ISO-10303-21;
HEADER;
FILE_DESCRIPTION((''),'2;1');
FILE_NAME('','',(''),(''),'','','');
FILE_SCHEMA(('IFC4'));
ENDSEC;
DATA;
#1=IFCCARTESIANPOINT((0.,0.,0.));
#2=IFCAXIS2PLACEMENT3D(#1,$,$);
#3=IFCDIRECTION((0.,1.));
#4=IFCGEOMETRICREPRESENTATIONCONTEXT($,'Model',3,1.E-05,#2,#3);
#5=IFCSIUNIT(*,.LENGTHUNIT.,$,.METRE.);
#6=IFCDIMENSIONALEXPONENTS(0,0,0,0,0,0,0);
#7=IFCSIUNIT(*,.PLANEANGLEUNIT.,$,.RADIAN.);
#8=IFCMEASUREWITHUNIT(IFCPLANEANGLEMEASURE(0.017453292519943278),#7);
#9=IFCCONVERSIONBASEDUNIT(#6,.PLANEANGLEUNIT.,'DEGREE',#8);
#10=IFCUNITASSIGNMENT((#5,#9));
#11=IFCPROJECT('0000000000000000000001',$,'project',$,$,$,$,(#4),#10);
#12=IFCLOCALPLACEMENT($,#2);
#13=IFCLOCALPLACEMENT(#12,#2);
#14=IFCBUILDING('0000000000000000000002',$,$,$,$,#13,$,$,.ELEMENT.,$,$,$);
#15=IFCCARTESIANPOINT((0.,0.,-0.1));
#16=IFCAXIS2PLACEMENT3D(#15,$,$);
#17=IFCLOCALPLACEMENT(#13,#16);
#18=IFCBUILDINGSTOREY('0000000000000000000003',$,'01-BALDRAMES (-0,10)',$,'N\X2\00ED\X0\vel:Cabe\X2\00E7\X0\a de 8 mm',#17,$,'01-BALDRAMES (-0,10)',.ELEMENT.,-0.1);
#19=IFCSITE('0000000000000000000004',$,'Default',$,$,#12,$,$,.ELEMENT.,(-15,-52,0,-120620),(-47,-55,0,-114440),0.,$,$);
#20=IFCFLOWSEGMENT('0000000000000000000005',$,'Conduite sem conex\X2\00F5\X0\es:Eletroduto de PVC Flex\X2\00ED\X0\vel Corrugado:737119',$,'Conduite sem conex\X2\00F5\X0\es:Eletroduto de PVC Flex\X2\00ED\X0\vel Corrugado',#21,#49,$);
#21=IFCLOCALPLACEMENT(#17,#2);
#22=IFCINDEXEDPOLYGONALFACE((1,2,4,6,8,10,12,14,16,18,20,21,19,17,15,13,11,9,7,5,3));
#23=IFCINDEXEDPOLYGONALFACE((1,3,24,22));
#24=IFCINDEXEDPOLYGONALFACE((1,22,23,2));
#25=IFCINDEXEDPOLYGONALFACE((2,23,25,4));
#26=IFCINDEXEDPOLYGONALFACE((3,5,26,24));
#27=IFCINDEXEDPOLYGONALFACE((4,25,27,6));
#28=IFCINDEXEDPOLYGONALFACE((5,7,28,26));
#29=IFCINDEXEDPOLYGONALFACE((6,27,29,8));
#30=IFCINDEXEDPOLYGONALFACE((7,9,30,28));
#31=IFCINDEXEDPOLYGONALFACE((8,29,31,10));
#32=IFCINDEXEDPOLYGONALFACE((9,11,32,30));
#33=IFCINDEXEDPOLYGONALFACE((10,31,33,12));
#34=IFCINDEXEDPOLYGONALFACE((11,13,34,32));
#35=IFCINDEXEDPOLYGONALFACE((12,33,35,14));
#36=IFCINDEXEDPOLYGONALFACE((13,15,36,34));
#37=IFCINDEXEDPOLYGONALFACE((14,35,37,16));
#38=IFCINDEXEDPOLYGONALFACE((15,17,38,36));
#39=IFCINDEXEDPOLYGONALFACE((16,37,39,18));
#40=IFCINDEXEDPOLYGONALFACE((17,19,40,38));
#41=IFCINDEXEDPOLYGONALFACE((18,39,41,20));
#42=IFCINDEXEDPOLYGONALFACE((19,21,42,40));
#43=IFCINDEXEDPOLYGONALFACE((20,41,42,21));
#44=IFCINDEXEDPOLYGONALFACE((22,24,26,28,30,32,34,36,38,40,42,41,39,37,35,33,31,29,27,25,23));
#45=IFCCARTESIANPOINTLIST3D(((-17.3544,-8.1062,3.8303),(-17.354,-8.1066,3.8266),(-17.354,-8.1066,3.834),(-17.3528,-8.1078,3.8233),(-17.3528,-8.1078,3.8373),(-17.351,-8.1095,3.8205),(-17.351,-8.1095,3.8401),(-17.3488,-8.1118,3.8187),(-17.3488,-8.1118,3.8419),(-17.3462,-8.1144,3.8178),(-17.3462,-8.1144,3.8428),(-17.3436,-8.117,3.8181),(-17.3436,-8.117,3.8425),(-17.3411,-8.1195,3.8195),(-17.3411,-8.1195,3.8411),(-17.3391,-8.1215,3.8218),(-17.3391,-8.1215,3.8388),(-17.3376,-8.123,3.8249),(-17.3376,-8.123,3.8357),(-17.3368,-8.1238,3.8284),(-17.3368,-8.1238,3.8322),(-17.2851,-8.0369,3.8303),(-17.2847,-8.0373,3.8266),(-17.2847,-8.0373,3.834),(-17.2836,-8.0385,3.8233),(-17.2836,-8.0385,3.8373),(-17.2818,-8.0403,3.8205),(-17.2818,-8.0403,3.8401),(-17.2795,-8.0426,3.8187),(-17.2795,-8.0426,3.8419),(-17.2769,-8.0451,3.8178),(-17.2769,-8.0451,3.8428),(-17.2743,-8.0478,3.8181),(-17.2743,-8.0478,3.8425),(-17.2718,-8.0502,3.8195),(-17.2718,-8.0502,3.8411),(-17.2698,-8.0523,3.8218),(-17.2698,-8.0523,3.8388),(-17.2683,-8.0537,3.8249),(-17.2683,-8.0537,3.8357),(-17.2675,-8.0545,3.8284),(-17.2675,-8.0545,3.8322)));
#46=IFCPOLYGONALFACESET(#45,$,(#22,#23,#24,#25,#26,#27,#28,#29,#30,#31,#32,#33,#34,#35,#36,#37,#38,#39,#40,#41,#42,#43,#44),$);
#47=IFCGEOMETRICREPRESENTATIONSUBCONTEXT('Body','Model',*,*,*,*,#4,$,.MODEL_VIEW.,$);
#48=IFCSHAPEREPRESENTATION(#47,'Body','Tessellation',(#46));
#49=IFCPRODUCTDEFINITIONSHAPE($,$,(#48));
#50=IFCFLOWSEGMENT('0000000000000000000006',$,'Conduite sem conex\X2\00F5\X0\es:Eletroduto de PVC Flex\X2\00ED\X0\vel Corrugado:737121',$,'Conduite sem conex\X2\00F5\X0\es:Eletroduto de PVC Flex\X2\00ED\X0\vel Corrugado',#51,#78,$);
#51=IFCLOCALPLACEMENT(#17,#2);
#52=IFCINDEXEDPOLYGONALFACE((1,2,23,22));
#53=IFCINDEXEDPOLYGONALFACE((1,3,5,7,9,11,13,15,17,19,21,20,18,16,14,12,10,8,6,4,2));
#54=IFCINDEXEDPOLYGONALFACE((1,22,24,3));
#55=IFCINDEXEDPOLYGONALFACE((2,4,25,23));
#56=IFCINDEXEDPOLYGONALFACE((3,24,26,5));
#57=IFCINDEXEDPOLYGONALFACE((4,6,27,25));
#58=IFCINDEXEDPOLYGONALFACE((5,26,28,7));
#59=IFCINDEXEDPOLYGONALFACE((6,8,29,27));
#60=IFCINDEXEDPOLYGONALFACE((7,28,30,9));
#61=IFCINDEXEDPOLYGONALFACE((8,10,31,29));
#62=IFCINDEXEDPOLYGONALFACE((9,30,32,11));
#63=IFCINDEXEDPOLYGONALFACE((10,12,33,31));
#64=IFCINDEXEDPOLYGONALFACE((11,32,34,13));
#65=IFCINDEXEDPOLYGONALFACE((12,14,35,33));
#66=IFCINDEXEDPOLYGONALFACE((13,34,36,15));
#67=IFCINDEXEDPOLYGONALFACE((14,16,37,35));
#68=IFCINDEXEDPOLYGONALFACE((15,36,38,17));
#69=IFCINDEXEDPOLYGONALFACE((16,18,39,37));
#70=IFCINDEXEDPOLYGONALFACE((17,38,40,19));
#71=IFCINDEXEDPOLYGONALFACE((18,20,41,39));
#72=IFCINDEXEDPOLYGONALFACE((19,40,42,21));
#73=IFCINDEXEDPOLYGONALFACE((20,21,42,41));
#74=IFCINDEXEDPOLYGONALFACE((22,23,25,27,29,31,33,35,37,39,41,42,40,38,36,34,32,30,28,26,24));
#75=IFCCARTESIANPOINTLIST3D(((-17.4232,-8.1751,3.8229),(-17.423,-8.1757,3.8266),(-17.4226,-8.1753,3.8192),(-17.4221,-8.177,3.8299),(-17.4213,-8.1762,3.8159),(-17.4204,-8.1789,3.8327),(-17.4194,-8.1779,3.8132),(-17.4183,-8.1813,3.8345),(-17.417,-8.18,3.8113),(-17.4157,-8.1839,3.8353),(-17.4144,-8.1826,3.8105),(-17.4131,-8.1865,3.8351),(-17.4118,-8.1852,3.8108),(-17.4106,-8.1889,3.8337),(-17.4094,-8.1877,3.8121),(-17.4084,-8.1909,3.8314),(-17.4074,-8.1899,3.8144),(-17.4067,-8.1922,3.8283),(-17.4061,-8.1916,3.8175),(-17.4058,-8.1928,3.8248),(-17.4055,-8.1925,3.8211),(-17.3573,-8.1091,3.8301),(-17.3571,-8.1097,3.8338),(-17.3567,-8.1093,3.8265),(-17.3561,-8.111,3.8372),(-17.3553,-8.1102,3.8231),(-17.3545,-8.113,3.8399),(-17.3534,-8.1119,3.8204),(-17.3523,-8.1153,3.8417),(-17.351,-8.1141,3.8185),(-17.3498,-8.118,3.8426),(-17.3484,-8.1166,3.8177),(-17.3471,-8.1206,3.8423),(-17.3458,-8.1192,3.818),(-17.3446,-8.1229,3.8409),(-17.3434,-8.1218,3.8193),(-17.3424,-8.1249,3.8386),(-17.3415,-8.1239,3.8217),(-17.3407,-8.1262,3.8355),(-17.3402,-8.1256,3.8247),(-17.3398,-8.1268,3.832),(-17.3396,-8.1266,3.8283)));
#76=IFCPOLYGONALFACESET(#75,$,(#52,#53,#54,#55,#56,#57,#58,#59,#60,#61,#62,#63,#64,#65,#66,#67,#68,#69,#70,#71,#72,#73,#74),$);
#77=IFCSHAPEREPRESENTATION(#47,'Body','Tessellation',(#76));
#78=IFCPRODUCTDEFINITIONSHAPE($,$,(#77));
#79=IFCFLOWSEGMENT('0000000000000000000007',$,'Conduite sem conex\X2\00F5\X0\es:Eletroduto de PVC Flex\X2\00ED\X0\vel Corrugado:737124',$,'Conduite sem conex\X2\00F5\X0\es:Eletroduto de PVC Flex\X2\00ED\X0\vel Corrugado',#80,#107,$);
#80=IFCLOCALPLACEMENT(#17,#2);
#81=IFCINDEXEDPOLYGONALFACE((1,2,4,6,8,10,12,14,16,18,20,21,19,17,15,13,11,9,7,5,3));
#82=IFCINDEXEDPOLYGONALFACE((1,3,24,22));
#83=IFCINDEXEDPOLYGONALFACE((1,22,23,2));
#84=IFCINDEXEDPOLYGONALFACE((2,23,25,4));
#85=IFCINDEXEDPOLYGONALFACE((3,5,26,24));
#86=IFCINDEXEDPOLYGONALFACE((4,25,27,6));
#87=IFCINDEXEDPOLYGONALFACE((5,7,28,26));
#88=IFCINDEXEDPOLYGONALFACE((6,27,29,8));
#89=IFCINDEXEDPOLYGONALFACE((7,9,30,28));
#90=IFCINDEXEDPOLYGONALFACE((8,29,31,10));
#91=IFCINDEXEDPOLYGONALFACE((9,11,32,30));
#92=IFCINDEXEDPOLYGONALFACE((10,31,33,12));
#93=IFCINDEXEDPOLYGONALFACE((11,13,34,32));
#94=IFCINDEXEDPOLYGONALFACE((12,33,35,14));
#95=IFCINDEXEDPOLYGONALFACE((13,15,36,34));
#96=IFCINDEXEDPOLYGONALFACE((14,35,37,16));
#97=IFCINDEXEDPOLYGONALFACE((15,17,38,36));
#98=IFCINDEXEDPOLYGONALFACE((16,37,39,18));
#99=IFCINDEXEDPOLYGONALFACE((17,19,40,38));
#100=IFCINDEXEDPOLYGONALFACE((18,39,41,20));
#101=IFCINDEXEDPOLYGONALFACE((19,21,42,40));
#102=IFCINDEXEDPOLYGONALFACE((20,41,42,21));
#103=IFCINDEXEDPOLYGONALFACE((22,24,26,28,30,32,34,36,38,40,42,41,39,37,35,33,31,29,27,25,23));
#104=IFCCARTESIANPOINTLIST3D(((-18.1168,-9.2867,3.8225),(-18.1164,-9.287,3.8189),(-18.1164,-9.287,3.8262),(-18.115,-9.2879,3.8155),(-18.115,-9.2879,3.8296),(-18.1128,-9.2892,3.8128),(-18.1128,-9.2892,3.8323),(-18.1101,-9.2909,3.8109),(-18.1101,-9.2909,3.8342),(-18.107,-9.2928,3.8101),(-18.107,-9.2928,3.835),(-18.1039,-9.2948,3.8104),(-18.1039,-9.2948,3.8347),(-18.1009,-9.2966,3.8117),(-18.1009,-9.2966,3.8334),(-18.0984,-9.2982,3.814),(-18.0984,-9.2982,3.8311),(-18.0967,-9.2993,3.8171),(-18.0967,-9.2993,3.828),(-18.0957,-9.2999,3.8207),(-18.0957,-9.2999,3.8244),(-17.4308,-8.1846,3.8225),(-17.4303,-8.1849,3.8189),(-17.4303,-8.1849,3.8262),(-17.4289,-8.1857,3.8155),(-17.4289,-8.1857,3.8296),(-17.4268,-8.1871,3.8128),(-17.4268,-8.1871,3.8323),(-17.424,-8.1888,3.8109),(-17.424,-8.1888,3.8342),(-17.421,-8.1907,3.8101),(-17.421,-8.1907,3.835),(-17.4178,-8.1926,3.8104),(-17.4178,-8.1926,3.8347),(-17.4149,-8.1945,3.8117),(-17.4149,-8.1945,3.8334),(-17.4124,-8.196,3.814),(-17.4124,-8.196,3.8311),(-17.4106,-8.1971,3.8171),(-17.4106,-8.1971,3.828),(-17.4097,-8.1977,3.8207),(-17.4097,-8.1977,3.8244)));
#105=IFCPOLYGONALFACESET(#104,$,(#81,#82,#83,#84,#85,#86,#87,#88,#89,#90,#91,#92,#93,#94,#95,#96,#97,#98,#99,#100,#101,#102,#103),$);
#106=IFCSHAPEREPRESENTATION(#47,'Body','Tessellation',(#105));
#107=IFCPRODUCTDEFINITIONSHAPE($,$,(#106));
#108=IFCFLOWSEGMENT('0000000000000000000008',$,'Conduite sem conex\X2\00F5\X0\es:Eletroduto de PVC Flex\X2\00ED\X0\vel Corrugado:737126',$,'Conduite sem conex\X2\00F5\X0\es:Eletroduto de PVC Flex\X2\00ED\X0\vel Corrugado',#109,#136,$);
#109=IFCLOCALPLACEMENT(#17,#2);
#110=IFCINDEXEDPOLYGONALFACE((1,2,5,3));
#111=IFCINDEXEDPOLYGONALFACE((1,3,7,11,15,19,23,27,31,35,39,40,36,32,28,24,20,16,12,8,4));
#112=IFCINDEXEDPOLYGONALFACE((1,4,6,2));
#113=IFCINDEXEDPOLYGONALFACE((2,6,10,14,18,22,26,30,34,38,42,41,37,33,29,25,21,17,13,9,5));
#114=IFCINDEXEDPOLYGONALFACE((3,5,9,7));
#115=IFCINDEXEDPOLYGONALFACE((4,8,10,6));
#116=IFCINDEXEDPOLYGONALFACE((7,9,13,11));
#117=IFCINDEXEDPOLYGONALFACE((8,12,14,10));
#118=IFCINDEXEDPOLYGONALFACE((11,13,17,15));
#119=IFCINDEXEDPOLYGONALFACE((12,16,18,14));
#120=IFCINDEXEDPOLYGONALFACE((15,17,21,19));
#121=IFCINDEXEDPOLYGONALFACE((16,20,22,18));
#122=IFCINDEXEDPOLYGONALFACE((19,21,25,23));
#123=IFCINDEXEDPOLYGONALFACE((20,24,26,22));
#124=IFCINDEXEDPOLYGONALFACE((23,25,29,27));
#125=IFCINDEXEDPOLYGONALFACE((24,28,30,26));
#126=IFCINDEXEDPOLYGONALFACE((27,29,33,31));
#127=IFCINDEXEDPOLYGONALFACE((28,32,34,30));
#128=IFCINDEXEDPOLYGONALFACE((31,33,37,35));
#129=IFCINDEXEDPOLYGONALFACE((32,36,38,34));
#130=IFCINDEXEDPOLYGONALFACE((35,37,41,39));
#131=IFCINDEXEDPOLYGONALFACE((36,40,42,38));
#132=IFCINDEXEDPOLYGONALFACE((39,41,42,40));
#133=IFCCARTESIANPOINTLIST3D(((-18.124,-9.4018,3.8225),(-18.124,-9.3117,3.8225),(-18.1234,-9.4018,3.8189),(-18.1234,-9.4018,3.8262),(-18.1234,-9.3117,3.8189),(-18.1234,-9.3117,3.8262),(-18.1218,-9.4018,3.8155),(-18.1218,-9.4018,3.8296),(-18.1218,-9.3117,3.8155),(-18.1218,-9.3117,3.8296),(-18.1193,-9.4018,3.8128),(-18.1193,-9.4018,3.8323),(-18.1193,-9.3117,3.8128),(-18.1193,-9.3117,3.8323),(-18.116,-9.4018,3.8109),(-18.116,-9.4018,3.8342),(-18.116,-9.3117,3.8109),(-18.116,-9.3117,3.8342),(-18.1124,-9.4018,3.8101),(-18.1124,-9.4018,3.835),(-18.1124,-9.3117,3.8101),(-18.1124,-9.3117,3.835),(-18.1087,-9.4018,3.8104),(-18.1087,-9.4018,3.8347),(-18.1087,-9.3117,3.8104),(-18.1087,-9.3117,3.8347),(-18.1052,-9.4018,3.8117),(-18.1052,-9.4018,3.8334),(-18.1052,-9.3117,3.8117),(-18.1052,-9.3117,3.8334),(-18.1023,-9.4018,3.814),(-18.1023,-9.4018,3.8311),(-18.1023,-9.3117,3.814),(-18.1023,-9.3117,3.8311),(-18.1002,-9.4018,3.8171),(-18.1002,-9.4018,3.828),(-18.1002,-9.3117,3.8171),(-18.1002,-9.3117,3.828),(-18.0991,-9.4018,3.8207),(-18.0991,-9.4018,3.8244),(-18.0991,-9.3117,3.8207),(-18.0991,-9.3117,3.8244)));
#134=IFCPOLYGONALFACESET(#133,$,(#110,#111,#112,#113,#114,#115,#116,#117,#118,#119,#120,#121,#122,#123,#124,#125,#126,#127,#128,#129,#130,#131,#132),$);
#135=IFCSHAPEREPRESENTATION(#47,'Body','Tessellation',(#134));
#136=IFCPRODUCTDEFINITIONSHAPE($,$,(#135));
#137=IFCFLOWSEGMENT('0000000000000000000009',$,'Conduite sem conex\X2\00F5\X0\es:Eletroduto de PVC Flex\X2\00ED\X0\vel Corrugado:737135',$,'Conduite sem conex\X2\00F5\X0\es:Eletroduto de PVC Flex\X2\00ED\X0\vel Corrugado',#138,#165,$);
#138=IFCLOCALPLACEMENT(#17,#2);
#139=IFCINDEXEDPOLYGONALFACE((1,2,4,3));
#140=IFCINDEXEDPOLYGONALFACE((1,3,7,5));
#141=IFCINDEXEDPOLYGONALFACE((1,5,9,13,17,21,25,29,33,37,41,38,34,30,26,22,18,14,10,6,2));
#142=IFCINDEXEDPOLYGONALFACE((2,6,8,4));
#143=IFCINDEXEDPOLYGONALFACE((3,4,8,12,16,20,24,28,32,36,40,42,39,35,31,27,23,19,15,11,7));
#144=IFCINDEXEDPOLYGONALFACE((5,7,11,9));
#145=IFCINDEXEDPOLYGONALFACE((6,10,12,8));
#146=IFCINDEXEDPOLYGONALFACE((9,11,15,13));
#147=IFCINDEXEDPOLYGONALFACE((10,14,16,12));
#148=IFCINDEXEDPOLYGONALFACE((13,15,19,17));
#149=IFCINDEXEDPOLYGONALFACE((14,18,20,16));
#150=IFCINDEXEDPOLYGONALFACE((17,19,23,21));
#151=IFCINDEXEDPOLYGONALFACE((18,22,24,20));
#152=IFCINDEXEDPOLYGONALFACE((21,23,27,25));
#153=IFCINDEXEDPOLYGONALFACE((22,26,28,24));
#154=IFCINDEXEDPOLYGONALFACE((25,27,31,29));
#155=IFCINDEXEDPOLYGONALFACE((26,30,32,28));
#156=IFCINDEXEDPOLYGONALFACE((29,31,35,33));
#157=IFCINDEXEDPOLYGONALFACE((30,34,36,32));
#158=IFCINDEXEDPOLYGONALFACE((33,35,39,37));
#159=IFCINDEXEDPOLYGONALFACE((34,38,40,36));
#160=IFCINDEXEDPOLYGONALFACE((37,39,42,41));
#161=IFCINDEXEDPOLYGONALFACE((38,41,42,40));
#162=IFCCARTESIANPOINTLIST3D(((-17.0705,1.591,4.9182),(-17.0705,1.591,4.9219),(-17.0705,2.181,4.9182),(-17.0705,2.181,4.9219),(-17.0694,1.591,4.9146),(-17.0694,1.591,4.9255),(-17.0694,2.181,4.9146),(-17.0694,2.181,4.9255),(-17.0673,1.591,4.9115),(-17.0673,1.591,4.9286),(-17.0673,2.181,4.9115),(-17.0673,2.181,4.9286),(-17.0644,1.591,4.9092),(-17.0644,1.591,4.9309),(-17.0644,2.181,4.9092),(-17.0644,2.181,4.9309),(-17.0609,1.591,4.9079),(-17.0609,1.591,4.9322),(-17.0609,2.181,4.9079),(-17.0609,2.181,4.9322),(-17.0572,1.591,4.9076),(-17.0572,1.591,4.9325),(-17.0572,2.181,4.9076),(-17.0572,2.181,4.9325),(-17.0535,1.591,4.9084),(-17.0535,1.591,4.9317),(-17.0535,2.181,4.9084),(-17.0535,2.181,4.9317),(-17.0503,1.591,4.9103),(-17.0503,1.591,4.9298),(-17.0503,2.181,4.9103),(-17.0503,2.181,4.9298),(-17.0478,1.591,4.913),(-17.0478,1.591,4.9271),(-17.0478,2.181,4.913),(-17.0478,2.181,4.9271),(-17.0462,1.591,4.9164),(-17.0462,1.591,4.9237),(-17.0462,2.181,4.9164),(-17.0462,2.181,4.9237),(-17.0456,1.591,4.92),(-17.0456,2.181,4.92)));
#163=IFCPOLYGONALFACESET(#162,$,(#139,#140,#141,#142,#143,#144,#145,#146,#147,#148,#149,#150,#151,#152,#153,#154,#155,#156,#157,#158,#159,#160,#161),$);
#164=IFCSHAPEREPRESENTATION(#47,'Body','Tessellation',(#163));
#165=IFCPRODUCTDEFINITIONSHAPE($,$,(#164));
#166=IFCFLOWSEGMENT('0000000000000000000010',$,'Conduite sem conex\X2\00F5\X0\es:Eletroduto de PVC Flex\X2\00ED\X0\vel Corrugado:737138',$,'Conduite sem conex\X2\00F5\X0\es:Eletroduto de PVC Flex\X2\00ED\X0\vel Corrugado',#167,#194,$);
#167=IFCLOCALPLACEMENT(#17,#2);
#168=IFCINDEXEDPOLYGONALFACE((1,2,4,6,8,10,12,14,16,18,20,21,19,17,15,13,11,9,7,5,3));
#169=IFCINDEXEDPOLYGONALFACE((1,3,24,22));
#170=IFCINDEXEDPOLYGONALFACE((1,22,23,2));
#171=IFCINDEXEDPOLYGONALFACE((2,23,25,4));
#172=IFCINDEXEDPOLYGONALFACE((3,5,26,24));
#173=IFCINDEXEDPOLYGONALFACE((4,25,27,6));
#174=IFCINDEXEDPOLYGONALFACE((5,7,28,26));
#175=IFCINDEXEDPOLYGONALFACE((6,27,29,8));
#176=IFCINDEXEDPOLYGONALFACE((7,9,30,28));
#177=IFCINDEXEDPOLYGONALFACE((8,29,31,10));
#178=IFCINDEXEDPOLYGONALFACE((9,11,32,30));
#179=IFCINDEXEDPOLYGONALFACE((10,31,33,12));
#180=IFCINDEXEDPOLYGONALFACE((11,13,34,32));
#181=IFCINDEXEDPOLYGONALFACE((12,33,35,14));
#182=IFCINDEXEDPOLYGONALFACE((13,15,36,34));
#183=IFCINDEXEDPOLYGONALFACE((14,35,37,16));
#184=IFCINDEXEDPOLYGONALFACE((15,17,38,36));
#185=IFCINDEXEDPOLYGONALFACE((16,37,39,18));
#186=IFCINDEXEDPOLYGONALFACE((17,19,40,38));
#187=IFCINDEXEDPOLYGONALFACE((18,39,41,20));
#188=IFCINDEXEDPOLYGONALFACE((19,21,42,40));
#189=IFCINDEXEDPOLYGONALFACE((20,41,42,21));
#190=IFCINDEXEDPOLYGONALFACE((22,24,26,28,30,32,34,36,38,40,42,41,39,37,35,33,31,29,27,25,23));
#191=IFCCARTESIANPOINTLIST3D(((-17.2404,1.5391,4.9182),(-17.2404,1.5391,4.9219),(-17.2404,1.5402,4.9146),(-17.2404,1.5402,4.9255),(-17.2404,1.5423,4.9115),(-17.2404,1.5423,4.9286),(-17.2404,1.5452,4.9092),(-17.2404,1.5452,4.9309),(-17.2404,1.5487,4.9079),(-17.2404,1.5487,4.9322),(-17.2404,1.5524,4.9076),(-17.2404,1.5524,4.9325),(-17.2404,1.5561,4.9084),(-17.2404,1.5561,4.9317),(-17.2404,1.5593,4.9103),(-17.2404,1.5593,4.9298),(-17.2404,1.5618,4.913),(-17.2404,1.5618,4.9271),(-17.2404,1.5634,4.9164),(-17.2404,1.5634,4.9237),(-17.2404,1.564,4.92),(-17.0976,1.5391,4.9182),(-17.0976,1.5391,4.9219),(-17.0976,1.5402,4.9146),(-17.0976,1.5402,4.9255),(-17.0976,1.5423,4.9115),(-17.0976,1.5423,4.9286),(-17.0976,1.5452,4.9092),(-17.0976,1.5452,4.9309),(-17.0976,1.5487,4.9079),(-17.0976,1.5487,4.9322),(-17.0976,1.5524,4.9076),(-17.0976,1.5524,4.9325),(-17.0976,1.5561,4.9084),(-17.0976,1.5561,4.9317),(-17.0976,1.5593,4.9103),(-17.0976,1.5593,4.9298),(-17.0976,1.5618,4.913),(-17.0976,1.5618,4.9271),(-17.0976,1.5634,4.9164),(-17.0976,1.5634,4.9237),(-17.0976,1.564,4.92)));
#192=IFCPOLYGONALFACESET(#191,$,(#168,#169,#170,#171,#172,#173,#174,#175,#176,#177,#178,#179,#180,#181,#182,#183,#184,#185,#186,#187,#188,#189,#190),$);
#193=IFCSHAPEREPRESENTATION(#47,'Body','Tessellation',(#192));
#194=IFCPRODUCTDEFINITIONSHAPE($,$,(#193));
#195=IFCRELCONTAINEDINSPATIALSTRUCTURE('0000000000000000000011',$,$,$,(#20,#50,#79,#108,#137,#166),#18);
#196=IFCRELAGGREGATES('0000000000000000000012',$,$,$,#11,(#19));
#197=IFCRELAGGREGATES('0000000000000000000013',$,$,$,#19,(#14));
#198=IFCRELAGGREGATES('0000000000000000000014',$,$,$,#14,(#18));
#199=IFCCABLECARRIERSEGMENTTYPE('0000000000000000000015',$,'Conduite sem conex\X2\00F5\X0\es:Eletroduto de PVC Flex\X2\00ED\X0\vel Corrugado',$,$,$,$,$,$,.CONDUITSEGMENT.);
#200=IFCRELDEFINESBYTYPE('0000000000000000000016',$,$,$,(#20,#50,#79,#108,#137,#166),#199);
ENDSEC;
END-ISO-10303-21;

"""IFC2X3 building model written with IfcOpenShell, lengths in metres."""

from ifc_helpers import new_model, entity, si_unit, converted_unit, direction, frame, frame_2d, origin, origin_2d_with_axis, place, context, subcontext, project, spatial, circle, extrude, type_object, element, save


model = new_model("IFC2X3")

# Units and contexts
model_context = context("Model", 3, precision=1e-05, world=origin(), true_north=direction((0.0, 1.0)))
body_context = subcontext(model_context, "Body", "Model", "MODEL_VIEW")
ifc_project = project(units=[si_unit("LENGTHUNIT", "METRE"), converted_unit("PLANEANGLEUNIT", "DEGREE", entity("IfcPlaneAngleMeasure", 0.017453292519943278), si_unit("PLANEANGLEUNIT", "RADIAN"), dimensions=[0, 0, 0, 0, 0, 0, 0])], contexts=[model_context])

# Site, building, storey
site_placement = place(None, origin())
site = spatial("IfcSite", under=ifc_project, at=site_placement, Name="Default", CompositionType="ELEMENT", RefLatitude=(-15, -52, 0, -120620), RefLongitude=(-47, -55, 0, -114440), RefElevation=0.0)
building_placement = place(site_placement, origin())
building = spatial("IfcBuilding", under=site, at=building_placement, CompositionType="ELEMENT")
storey_placement = place(building_placement, frame((0.0, 0.0, -0.1)))
storey = spatial("IfcBuildingStorey", under=building, at=storey_placement, Name="01-BALDRAMES (-0,10)", ObjectType="Nível:Cabeça de 8 mm", LongName="01-BALDRAMES (-0,10)", CompositionType="ELEMENT", Elevation=-0.1)

# Flow segments
cable_carrier_segment_type = type_object("IfcCableCarrierSegmentType", Name="Conduite sem conexões:Eletroduto de PVC Flexível Corrugado", PredefinedType="CONDUITSEGMENT")
flow_segment_1_placement = place(storey_placement, origin())
element("IfcFlowSegment", 1, at=flow_segment_1_placement, inside=storey, type_object=cable_carrier_segment_type, Name="Conduite sem conexões:Eletroduto de PVC Flexível Corrugado:737119", ObjectType="Conduite sem conexões:Eletroduto de PVC Flexível Corrugado", context=body_context, shape_type="SweptSolid", body=[
    extrude(circle(Radius=0.0125, at=frame_2d((0.0, 0.0), x_axis=(1.0, 0.0))), frame((-17.3455, -8.1151, 3.8303), z_axis=(0.707107, 0.707107, 0.0), x_axis=(-0.707107, 0.707107, 0.0)), (0.0, 0.0, 1.0), 0.098),
])
flow_segment_2_placement = place(storey_placement, origin())
element("IfcFlowSegment", 2, at=flow_segment_2_placement, inside=storey, type_object=cable_carrier_segment_type, Name="Conduite sem conexões:Eletroduto de PVC Flexível Corrugado:737121", ObjectType="Conduite sem conexões:Eletroduto de PVC Flexível Corrugado", context=body_context, shape_type="SweptSolid", body=[
    extrude(circle(Radius=0.0125, at=origin_2d_with_axis()), frame((-17.4144, -8.1839, 3.8229), z_axis=(0.704993, 0.704993, 0.077268), x_axis=(-0.707107, 0.707107, 0.0)), (0.0, 0.0, 1.0), 0.0936),
])
flow_segment_3_placement = place(storey_placement, origin())
element("IfcFlowSegment", 3, at=flow_segment_3_placement, inside=storey, type_object=cable_carrier_segment_type, Name="Conduite sem conexões:Eletroduto de PVC Flexível Corrugado:737124", ObjectType="Conduite sem conexões:Eletroduto de PVC Flexível Corrugado", context=body_context, shape_type="SweptSolid", body=[
    extrude(circle(Radius=0.0125, at=frame_2d((0.0, 0.0), x_axis=(1.0, 0.0))), frame((-18.1062, -9.2933, 3.8225), z_axis=(0.528455, 0.848962, 0.0), x_axis=(-0.848962, 0.528455, 0.0)), (0.0, 0.0, 1.0), 1.2982),
])
flow_segment_4_placement = place(storey_placement, origin())
element("IfcFlowSegment", 4, at=flow_segment_4_placement, inside=storey, type_object=cable_carrier_segment_type, Name="Conduite sem conexões:Eletroduto de PVC Flexível Corrugado:737126", ObjectType="Conduite sem conexões:Eletroduto de PVC Flexível Corrugado", context=body_context, shape_type="SweptSolid", body=[
    extrude(circle(Radius=0.0125, at=frame_2d((0.0, 0.0), x_axis=(1.0, 0.0))), frame((-18.1115, -9.4018, 3.8225), z_axis=(0.0, 1.0, 0.0), x_axis=(-1.0, 0.0, 0.0)), (0.0, 0.0, 1.0), 0.0901),
])
flow_segment_5_placement = place(storey_placement, origin())
element("IfcFlowSegment", 5, at=flow_segment_5_placement, inside=storey, type_object=cable_carrier_segment_type, Name="Conduite sem conexões:Eletroduto de PVC Flexível Corrugado:737135", ObjectType="Conduite sem conexões:Eletroduto de PVC Flexível Corrugado", context=body_context, shape_type="SweptSolid", body=[
    extrude(circle(Radius=0.0125, at=origin_2d_with_axis()), frame((-17.0581, 1.591, 4.92), z_axis=(0.0, 1.0, 0.0), x_axis=(1.0, 0.0, 0.0)), (0.0, 0.0, 1.0), 0.59),
])
flow_segment_6_placement = place(storey_placement, origin())
element("IfcFlowSegment", 6, at=flow_segment_6_placement, inside=storey, type_object=cable_carrier_segment_type, Name="Conduite sem conexões:Eletroduto de PVC Flexível Corrugado:737138", ObjectType="Conduite sem conexões:Eletroduto de PVC Flexível Corrugado", context=body_context, shape_type="SweptSolid", body=[
    extrude(circle(Radius=0.0125, at=frame_2d((0.0, 0.0), x_axis=(1.0, 0.0))), frame((-17.2404, 1.5515, 4.92), z_axis=(1.0, 0.0, 0.0), x_axis=(0.0, 1.0, 0.0)), (0.0, 0.0, 1.0), 0.1428),
])

save(model, "model.ifc")
